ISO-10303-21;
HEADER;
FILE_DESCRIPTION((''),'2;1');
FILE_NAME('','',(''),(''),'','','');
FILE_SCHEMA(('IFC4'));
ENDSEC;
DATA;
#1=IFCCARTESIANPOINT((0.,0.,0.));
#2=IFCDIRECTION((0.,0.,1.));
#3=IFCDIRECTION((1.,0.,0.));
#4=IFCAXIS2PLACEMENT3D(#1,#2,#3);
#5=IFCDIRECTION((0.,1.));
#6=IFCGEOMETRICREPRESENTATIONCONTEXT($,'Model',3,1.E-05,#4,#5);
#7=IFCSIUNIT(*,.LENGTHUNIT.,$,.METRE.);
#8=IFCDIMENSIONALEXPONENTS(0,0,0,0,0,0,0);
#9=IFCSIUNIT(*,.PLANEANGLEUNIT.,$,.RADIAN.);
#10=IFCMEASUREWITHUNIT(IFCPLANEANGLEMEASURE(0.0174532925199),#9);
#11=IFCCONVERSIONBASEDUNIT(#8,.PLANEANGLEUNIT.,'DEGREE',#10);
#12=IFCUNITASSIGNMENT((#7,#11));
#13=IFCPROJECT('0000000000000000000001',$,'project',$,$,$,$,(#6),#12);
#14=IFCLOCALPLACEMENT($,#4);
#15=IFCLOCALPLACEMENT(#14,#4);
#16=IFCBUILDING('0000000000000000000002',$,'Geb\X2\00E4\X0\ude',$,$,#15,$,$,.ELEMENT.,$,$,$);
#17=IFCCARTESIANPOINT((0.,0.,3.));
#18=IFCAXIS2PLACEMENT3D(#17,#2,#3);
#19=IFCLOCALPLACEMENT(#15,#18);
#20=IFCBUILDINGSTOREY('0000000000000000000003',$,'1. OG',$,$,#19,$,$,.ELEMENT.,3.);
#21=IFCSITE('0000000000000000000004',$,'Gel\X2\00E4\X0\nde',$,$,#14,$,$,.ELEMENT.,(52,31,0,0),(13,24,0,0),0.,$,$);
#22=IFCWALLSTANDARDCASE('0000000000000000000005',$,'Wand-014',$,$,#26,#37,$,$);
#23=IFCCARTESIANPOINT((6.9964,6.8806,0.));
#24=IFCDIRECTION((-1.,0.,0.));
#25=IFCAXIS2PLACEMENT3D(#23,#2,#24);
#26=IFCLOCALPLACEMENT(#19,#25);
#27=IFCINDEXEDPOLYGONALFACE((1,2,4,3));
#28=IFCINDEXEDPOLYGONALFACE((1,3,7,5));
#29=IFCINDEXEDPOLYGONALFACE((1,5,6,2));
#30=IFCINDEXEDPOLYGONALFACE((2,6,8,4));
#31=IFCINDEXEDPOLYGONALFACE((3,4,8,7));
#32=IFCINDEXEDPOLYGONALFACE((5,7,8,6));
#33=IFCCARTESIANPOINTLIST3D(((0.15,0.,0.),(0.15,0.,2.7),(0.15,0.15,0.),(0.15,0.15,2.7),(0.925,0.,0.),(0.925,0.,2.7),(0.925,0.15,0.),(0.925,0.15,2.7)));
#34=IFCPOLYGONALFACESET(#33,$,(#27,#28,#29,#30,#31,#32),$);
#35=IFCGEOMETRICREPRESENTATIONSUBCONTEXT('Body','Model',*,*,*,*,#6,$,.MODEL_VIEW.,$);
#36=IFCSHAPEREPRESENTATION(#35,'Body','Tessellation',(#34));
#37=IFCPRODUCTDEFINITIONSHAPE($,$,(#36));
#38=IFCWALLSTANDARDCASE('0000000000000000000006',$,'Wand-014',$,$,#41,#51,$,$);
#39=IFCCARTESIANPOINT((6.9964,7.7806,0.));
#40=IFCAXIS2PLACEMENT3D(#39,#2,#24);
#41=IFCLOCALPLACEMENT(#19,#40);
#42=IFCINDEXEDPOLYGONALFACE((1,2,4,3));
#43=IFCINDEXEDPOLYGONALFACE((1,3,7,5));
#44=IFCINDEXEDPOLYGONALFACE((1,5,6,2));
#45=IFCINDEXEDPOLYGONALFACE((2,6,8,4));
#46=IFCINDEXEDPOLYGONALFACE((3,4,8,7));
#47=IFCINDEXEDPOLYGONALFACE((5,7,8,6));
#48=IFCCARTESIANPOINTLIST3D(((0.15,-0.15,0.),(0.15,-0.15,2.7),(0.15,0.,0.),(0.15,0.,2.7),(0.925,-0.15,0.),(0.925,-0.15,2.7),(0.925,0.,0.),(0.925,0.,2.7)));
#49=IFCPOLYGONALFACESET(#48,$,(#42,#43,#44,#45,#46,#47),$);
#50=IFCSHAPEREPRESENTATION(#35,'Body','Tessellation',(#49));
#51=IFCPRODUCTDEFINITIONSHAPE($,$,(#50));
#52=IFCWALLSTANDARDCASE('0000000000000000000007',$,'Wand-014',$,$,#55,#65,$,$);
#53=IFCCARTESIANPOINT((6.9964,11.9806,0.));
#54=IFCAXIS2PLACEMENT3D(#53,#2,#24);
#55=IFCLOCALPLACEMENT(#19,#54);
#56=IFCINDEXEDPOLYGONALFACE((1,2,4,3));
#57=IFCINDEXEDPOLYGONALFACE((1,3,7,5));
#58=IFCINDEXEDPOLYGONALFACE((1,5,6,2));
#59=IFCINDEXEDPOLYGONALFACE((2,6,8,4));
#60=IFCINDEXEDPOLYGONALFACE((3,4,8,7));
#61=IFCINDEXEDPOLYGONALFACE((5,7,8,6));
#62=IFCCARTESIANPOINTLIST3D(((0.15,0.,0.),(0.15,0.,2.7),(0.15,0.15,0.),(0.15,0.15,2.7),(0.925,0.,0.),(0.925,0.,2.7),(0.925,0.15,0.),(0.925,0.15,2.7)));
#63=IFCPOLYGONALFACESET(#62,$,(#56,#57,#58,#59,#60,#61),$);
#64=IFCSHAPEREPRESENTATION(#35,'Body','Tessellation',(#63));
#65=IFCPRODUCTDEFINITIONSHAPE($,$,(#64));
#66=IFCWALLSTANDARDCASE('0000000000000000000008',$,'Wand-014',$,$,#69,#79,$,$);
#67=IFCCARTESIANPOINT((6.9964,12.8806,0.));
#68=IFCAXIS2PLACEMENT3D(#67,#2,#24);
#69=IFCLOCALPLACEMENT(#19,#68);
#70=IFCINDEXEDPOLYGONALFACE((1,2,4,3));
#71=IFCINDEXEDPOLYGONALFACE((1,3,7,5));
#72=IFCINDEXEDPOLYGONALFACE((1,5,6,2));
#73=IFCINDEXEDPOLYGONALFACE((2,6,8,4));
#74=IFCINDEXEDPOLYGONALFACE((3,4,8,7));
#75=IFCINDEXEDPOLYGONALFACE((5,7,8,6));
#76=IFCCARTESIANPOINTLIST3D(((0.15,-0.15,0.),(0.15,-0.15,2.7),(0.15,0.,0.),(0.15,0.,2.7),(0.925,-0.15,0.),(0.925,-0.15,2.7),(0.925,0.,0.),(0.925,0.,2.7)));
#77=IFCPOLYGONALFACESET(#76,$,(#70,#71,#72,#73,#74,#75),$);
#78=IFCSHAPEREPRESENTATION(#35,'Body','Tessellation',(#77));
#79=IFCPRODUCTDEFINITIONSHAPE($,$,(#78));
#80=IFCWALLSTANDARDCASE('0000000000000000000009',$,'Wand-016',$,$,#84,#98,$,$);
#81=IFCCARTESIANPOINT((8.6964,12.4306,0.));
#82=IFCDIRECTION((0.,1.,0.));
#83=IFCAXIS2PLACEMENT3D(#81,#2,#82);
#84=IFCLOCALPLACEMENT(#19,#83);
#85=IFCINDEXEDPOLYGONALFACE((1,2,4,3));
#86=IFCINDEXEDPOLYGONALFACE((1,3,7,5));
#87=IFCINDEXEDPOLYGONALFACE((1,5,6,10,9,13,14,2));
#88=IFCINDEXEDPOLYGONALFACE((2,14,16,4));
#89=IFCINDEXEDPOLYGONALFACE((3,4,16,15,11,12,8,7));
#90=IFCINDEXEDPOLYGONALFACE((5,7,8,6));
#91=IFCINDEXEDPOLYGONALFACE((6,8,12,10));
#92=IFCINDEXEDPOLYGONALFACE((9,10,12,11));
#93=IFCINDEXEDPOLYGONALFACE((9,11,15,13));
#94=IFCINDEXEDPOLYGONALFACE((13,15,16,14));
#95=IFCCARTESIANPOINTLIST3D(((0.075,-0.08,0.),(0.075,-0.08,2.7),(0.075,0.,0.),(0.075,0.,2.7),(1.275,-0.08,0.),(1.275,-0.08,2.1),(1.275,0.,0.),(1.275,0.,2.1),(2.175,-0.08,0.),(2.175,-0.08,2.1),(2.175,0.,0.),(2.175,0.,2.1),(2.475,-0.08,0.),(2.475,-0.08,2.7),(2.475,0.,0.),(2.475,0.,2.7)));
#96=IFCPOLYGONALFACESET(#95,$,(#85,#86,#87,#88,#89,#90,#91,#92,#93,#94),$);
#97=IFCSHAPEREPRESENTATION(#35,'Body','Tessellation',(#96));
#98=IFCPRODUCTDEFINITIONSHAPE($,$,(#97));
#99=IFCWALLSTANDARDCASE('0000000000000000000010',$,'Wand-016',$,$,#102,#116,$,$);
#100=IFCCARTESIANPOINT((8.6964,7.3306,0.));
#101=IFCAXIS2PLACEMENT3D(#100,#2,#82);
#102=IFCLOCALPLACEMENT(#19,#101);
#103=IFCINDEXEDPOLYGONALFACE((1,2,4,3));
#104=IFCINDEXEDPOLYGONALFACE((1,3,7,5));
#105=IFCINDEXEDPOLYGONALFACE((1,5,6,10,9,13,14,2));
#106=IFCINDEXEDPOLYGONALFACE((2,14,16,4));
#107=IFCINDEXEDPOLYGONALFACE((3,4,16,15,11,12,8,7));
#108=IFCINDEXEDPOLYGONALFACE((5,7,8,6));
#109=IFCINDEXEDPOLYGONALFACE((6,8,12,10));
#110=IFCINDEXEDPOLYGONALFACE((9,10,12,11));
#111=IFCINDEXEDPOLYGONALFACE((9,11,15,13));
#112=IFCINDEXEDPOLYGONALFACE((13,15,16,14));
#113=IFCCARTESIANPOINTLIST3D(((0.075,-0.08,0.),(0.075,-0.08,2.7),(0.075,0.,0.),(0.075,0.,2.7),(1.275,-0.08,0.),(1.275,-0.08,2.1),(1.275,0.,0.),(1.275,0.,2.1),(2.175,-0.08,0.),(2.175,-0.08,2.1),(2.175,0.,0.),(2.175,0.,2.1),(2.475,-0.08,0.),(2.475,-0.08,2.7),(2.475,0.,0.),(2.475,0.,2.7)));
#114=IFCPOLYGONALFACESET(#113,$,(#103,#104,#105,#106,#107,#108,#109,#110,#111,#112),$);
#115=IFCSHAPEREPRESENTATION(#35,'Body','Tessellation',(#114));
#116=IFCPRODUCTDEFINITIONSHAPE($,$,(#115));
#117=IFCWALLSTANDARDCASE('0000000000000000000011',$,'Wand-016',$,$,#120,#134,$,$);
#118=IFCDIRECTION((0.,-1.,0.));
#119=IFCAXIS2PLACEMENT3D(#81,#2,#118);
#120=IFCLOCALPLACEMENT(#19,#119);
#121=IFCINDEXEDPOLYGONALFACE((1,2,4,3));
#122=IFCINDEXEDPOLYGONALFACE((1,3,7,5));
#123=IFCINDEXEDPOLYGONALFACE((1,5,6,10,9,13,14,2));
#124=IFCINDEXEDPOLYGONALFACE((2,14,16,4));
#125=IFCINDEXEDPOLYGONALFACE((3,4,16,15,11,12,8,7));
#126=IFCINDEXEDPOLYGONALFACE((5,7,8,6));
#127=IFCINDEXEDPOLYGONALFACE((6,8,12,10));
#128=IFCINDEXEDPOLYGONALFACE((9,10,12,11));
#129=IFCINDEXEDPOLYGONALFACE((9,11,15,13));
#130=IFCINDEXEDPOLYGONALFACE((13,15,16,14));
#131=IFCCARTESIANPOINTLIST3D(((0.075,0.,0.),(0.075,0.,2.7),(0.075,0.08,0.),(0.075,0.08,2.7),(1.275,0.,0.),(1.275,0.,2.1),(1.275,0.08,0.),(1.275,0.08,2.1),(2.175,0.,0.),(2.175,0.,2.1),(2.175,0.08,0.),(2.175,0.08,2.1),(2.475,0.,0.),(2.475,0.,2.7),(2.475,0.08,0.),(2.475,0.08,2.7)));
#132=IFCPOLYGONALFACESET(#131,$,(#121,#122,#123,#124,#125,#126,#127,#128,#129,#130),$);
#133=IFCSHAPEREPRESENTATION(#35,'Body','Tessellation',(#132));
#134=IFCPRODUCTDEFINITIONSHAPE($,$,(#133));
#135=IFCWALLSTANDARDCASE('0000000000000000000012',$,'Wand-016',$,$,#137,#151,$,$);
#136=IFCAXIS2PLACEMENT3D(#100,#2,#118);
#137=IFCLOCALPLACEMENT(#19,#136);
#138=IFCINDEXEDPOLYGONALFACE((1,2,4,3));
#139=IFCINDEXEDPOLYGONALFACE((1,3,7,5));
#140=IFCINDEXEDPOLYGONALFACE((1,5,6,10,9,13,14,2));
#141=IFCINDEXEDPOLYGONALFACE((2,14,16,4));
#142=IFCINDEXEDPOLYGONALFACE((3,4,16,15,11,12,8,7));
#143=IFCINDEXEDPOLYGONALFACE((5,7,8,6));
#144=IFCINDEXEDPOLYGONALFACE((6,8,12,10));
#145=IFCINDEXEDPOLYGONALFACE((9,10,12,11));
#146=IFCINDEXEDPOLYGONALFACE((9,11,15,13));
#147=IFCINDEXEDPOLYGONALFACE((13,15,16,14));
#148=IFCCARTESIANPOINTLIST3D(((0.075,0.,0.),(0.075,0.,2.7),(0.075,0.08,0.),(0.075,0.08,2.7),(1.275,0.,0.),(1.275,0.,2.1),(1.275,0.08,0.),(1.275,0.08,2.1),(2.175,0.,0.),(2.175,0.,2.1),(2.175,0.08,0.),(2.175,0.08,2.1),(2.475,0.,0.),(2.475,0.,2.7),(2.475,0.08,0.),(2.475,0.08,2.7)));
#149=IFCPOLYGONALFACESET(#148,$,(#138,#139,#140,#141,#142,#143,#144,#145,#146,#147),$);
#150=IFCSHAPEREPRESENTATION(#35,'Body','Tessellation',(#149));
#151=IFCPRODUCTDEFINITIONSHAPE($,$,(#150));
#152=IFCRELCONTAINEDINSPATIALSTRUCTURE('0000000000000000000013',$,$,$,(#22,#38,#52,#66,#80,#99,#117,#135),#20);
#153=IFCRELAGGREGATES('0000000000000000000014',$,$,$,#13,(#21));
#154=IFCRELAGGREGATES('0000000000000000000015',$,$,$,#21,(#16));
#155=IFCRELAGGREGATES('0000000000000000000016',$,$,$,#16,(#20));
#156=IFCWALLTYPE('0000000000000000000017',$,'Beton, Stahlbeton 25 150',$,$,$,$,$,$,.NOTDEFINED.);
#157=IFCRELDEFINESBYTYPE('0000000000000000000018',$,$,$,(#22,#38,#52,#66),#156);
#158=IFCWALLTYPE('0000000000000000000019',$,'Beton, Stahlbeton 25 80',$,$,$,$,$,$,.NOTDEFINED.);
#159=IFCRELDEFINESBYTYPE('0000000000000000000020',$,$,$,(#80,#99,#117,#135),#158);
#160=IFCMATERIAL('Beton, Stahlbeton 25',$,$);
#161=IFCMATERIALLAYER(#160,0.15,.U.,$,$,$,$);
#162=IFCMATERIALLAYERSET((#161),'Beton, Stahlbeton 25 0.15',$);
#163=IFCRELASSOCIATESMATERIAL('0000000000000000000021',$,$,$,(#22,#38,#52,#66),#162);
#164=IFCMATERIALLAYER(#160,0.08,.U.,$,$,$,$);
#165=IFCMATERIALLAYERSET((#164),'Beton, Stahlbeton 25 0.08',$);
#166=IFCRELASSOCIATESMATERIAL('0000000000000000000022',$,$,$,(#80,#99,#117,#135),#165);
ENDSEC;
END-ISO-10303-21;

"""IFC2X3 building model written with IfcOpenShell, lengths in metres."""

from ifc_helpers import new_model, entity, si_unit, converted_unit, direction, frame, origin_with_axes, origin_2d_with_axis, place, context, subcontext, project, spatial, polyline, rectangle, outline, extrude, material, layer, layer_set, layer_usage, type_object, element, save


model = new_model("IFC2X3")

# Units and contexts
model_context = context("Model", 3, precision=1e-05, world=origin_with_axes(), true_north=direction((0.0, 1.0)))
body_context = subcontext(model_context, "Body", "Model", "MODEL_VIEW")
ifc_project = project(units=[si_unit("LENGTHUNIT", "METRE"), converted_unit("PLANEANGLEUNIT", "DEGREE", entity("IfcPlaneAngleMeasure", 0.0174532925199), si_unit("PLANEANGLEUNIT", "RADIAN"), dimensions=[0, 0, 0, 0, 0, 0, 0])], contexts=[model_context])

# Site, building, storey
site_placement = place(None, origin_with_axes())
site = spatial("IfcSite", under=ifc_project, at=site_placement, Name="Gelände", CompositionType="ELEMENT", RefLatitude=(52, 31, 0, 0), RefLongitude=(13, 24, 0, 0), RefElevation=0.0)
building_placement = place(site_placement, origin_with_axes())
building = spatial("IfcBuilding", under=site, at=building_placement, Name="Gebäude", CompositionType="ELEMENT")
storey_placement = place(building_placement, frame((0.0, 0.0, 3.0), z_axis=(0.0, 0.0, 1.0), x_axis=(1.0, 0.0, 0.0)))
storey = spatial("IfcBuildingStorey", under=building, at=storey_placement, Name="1. OG", CompositionType="ELEMENT", Elevation=3.0)

# Walls
ifc_material = material(Name="Beton, Stahlbeton 25")
ifc_layer_1 = layer(ifc_material, 0.15, ventilated="UNKNOWN")
ifc_layer_set_1 = layer_set([ifc_layer_1], Name="Beton, Stahlbeton 25 0.15")
wall_type_1 = type_object("IfcWallType", Name="Beton, Stahlbeton 25 150", PredefinedType="NOTDEFINED")
ifc_layer_usage_1 = layer_usage(ifc_layer_set_1, "AXIS2", "POSITIVE", 0.0)
wall_1_placement = place(storey_placement, frame((6.9964, 6.8806, 0.0), z_axis=(0.0, 0.0, 1.0), x_axis=(-1.0, 0.0, 0.0)))
element("IfcWallStandardCase", 1, at=wall_1_placement, inside=storey, type_object=wall_type_1, material=ifc_layer_usage_1, Name="Wand-014", context=body_context, shape_type="SweptSolid", body=[
    extrude(outline(polyline([(0.15, 0.0), (0.925, 0.0), (0.925, 0.15), (0.15, 0.15), (0.15, 0.0)])), origin_with_axes(), (0.0, 0.0, 1.0), 2.7),
])
ifc_layer_usage_2 = layer_usage(ifc_layer_set_1, "AXIS2", "NEGATIVE", 0.0)
wall_2_placement = place(storey_placement, frame((6.9964, 7.7806, 0.0), z_axis=(0.0, 0.0, 1.0), x_axis=(-1.0, 0.0, 0.0)))
element("IfcWallStandardCase", 2, at=wall_2_placement, inside=storey, type_object=wall_type_1, material=ifc_layer_usage_2, Name="Wand-014", context=body_context, shape_type="SweptSolid", body=[
    extrude(outline(polyline([(0.15, -0.15), (0.925, -0.15), (0.925, 0.0), (0.15, 0.0), (0.15, -0.15)])), origin_with_axes(), (0.0, 0.0, 1.0), 2.7),
])
ifc_layer_usage_3 = layer_usage(ifc_layer_set_1, "AXIS2", "POSITIVE", 0.0)
wall_3_placement = place(storey_placement, frame((6.9964, 11.9806, 0.0), z_axis=(0.0, 0.0, 1.0), x_axis=(-1.0, 0.0, 0.0)))
element("IfcWallStandardCase", 3, at=wall_3_placement, inside=storey, type_object=wall_type_1, material=ifc_layer_usage_3, Name="Wand-014", context=body_context, shape_type="SweptSolid", body=[
    extrude(outline(polyline([(0.15, 0.0), (0.925, 0.0), (0.925, 0.15), (0.15, 0.15), (0.15, 0.0)])), origin_with_axes(), (0.0, 0.0, 1.0), 2.7),
])

# Wall
ifc_layer_usage_4 = layer_usage(ifc_layer_set_1, "AXIS2", "NEGATIVE", 0.0)
wall_4_placement = place(storey_placement, frame((6.9964, 12.8806, 0.0), z_axis=(0.0, 0.0, 1.0), x_axis=(-1.0, 0.0, 0.0)))
element("IfcWallStandardCase", 4, at=wall_4_placement, inside=storey, type_object=wall_type_1, material=ifc_layer_usage_4, Name="Wand-014", context=body_context, shape_type="SweptSolid", body=[
    extrude(outline(polyline([(0.15, -0.15), (0.925, -0.15), (0.925, 0.0), (0.15, 0.0), (0.15, -0.15)])), origin_with_axes(), (0.0, 0.0, 1.0), 2.7),
])

# Walls, openings
ifc_layer_2 = layer(ifc_material, 0.08, ventilated="UNKNOWN")
ifc_layer_set_2 = layer_set([ifc_layer_2], Name="Beton, Stahlbeton 25 0.08")
ifc_layer_usage_5 = layer_usage(ifc_layer_set_2, "AXIS2", "NEGATIVE", 0.0)
wall_type_2 = type_object("IfcWallType", Name="Beton, Stahlbeton 25 80", PredefinedType="NOTDEFINED")
wall_5_placement = place(storey_placement, frame((8.6964, 12.4306, 0.0), z_axis=(0.0, 0.0, 1.0), x_axis=(0.0, 1.0, 0.0)))
wall_5 = element("IfcWallStandardCase", 5, at=wall_5_placement, inside=storey, type_object=wall_type_2, material=ifc_layer_usage_5, Name="Wand-016", context=body_context, shape_type="SweptSolid", body=[
    extrude(outline(polyline([(0.075, -0.08), (2.475, -0.08), (2.475, 0.0), (0.075, 0.0), (0.075, -0.08)])), origin_with_axes(), (0.0, 0.0, 1.0), 2.7),
])
opening_1_placement = place(wall_5_placement, frame((1.725, 0.0, 0.0), z_axis=(0.0, 0.0, 1.0), x_axis=(1.0, 0.0, 0.0)))
element("IfcOpeningElement", 6, at=opening_1_placement, cuts=wall_5, context=body_context, shape_type="SweptSolid", body=[
    extrude(rectangle(XDim=0.9, YDim=2.1, at=origin_2d_with_axis()), frame((0.0, -0.16, 1.05), z_axis=(0.0, 1.0, 0.0), x_axis=(1.0, 0.0, 0.0)), (0.0, 0.0, 1.0), 0.08),
    extrude(rectangle(XDim=0.9, YDim=2.1, at=origin_2d_with_axis()), frame((0.0, 0.0, 1.05), z_axis=(0.0, -1.0, 0.0), x_axis=(1.0, 0.0, 0.0)), (0.0, 0.0, 1.0), 0.08),
])
ifc_layer_usage_6 = layer_usage(ifc_layer_set_2, "AXIS2", "NEGATIVE", 0.0)
wall_6_placement = place(storey_placement, frame((8.6964, 7.3306, 0.0), z_axis=(0.0, 0.0, 1.0), x_axis=(0.0, 1.0, 0.0)))
wall_6 = element("IfcWallStandardCase", 7, at=wall_6_placement, inside=storey, type_object=wall_type_2, material=ifc_layer_usage_6, Name="Wand-016", context=body_context, shape_type="SweptSolid", body=[
    extrude(outline(polyline([(0.075, -0.08), (2.475, -0.08), (2.475, 0.0), (0.075, 0.0), (0.075, -0.08)])), origin_with_axes(), (0.0, 0.0, 1.0), 2.7),
])
opening_2_placement = place(wall_6_placement, frame((1.725, 0.0, 0.0), z_axis=(0.0, 0.0, 1.0), x_axis=(1.0, 0.0, 0.0)))
element("IfcOpeningElement", 8, at=opening_2_placement, cuts=wall_6, context=body_context, shape_type="SweptSolid", body=[
    extrude(rectangle(XDim=0.9, YDim=2.1, at=origin_2d_with_axis()), frame((0.0, -0.16, 1.05), z_axis=(0.0, 1.0, 0.0), x_axis=(1.0, 0.0, 0.0)), (0.0, 0.0, 1.0), 0.08),
    extrude(rectangle(XDim=0.9, YDim=2.1, at=origin_2d_with_axis()), frame((0.0, 0.0, 1.05), z_axis=(0.0, -1.0, 0.0), x_axis=(1.0, 0.0, 0.0)), (0.0, 0.0, 1.0), 0.08),
])
ifc_layer_usage_7 = layer_usage(ifc_layer_set_2, "AXIS2", "POSITIVE", 0.0)
wall_7_placement = place(storey_placement, frame((8.6964, 12.4306, 0.0), z_axis=(0.0, 0.0, 1.0), x_axis=(0.0, -1.0, 0.0)))
wall_7 = element("IfcWallStandardCase", 9, at=wall_7_placement, inside=storey, type_object=wall_type_2, material=ifc_layer_usage_7, Name="Wand-016", context=body_context, shape_type="SweptSolid", body=[
    extrude(outline(polyline([(0.075, 0.0), (2.475, 0.0), (2.475, 0.08), (0.075, 0.08), (0.075, 0.0)])), origin_with_axes(), (0.0, 0.0, 1.0), 2.7),
])
opening_3_placement = place(wall_7_placement, frame((1.725, 0.0, 0.0), z_axis=(0.0, 0.0, 1.0), x_axis=(1.0, 0.0, 0.0)))
element("IfcOpeningElement", 10, at=opening_3_placement, cuts=wall_7, context=body_context, shape_type="SweptSolid", body=[
    extrude(rectangle(XDim=0.9, YDim=2.1, at=origin_2d_with_axis()), frame((0.0, 0.16, 1.05), z_axis=(0.0, -1.0, 0.0), x_axis=(1.0, 0.0, 0.0)), (0.0, 0.0, 1.0), 0.08),
    extrude(rectangle(XDim=0.9, YDim=2.1, at=origin_2d_with_axis()), frame((0.0, 0.0, 1.05), z_axis=(0.0, 1.0, 0.0), x_axis=(1.0, 0.0, 0.0)), (0.0, 0.0, 1.0), 0.08),
])
ifc_layer_usage_8 = layer_usage(ifc_layer_set_2, "AXIS2", "POSITIVE", 0.0)
wall_8_placement = place(storey_placement, frame((8.6964, 7.3306, 0.0), z_axis=(0.0, 0.0, 1.0), x_axis=(0.0, -1.0, 0.0)))
wall_8 = element("IfcWallStandardCase", 11, at=wall_8_placement, inside=storey, type_object=wall_type_2, material=ifc_layer_usage_8, Name="Wand-016", context=body_context, shape_type="SweptSolid", body=[
    extrude(outline(polyline([(0.075, 0.0), (2.475, 0.0), (2.475, 0.08), (0.075, 0.08), (0.075, 0.0)])), origin_with_axes(), (0.0, 0.0, 1.0), 2.7),
])
opening_4_placement = place(wall_8_placement, frame((1.725, 0.0, 0.0), z_axis=(0.0, 0.0, 1.0), x_axis=(1.0, 0.0, 0.0)))
element("IfcOpeningElement", 12, at=opening_4_placement, cuts=wall_8, context=body_context, shape_type="SweptSolid", body=[
    extrude(rectangle(XDim=0.9, YDim=2.1, at=origin_2d_with_axis()), frame((0.0, 0.16, 1.05), z_axis=(0.0, -1.0, 0.0), x_axis=(1.0, 0.0, 0.0)), (0.0, 0.0, 1.0), 0.08),
    extrude(rectangle(XDim=0.9, YDim=2.1, at=origin_2d_with_axis()), frame((0.0, 0.0, 1.05), z_axis=(0.0, 1.0, 0.0), x_axis=(1.0, 0.0, 0.0)), (0.0, 0.0, 1.0), 0.08),
])

save(model, "model.ifc")
